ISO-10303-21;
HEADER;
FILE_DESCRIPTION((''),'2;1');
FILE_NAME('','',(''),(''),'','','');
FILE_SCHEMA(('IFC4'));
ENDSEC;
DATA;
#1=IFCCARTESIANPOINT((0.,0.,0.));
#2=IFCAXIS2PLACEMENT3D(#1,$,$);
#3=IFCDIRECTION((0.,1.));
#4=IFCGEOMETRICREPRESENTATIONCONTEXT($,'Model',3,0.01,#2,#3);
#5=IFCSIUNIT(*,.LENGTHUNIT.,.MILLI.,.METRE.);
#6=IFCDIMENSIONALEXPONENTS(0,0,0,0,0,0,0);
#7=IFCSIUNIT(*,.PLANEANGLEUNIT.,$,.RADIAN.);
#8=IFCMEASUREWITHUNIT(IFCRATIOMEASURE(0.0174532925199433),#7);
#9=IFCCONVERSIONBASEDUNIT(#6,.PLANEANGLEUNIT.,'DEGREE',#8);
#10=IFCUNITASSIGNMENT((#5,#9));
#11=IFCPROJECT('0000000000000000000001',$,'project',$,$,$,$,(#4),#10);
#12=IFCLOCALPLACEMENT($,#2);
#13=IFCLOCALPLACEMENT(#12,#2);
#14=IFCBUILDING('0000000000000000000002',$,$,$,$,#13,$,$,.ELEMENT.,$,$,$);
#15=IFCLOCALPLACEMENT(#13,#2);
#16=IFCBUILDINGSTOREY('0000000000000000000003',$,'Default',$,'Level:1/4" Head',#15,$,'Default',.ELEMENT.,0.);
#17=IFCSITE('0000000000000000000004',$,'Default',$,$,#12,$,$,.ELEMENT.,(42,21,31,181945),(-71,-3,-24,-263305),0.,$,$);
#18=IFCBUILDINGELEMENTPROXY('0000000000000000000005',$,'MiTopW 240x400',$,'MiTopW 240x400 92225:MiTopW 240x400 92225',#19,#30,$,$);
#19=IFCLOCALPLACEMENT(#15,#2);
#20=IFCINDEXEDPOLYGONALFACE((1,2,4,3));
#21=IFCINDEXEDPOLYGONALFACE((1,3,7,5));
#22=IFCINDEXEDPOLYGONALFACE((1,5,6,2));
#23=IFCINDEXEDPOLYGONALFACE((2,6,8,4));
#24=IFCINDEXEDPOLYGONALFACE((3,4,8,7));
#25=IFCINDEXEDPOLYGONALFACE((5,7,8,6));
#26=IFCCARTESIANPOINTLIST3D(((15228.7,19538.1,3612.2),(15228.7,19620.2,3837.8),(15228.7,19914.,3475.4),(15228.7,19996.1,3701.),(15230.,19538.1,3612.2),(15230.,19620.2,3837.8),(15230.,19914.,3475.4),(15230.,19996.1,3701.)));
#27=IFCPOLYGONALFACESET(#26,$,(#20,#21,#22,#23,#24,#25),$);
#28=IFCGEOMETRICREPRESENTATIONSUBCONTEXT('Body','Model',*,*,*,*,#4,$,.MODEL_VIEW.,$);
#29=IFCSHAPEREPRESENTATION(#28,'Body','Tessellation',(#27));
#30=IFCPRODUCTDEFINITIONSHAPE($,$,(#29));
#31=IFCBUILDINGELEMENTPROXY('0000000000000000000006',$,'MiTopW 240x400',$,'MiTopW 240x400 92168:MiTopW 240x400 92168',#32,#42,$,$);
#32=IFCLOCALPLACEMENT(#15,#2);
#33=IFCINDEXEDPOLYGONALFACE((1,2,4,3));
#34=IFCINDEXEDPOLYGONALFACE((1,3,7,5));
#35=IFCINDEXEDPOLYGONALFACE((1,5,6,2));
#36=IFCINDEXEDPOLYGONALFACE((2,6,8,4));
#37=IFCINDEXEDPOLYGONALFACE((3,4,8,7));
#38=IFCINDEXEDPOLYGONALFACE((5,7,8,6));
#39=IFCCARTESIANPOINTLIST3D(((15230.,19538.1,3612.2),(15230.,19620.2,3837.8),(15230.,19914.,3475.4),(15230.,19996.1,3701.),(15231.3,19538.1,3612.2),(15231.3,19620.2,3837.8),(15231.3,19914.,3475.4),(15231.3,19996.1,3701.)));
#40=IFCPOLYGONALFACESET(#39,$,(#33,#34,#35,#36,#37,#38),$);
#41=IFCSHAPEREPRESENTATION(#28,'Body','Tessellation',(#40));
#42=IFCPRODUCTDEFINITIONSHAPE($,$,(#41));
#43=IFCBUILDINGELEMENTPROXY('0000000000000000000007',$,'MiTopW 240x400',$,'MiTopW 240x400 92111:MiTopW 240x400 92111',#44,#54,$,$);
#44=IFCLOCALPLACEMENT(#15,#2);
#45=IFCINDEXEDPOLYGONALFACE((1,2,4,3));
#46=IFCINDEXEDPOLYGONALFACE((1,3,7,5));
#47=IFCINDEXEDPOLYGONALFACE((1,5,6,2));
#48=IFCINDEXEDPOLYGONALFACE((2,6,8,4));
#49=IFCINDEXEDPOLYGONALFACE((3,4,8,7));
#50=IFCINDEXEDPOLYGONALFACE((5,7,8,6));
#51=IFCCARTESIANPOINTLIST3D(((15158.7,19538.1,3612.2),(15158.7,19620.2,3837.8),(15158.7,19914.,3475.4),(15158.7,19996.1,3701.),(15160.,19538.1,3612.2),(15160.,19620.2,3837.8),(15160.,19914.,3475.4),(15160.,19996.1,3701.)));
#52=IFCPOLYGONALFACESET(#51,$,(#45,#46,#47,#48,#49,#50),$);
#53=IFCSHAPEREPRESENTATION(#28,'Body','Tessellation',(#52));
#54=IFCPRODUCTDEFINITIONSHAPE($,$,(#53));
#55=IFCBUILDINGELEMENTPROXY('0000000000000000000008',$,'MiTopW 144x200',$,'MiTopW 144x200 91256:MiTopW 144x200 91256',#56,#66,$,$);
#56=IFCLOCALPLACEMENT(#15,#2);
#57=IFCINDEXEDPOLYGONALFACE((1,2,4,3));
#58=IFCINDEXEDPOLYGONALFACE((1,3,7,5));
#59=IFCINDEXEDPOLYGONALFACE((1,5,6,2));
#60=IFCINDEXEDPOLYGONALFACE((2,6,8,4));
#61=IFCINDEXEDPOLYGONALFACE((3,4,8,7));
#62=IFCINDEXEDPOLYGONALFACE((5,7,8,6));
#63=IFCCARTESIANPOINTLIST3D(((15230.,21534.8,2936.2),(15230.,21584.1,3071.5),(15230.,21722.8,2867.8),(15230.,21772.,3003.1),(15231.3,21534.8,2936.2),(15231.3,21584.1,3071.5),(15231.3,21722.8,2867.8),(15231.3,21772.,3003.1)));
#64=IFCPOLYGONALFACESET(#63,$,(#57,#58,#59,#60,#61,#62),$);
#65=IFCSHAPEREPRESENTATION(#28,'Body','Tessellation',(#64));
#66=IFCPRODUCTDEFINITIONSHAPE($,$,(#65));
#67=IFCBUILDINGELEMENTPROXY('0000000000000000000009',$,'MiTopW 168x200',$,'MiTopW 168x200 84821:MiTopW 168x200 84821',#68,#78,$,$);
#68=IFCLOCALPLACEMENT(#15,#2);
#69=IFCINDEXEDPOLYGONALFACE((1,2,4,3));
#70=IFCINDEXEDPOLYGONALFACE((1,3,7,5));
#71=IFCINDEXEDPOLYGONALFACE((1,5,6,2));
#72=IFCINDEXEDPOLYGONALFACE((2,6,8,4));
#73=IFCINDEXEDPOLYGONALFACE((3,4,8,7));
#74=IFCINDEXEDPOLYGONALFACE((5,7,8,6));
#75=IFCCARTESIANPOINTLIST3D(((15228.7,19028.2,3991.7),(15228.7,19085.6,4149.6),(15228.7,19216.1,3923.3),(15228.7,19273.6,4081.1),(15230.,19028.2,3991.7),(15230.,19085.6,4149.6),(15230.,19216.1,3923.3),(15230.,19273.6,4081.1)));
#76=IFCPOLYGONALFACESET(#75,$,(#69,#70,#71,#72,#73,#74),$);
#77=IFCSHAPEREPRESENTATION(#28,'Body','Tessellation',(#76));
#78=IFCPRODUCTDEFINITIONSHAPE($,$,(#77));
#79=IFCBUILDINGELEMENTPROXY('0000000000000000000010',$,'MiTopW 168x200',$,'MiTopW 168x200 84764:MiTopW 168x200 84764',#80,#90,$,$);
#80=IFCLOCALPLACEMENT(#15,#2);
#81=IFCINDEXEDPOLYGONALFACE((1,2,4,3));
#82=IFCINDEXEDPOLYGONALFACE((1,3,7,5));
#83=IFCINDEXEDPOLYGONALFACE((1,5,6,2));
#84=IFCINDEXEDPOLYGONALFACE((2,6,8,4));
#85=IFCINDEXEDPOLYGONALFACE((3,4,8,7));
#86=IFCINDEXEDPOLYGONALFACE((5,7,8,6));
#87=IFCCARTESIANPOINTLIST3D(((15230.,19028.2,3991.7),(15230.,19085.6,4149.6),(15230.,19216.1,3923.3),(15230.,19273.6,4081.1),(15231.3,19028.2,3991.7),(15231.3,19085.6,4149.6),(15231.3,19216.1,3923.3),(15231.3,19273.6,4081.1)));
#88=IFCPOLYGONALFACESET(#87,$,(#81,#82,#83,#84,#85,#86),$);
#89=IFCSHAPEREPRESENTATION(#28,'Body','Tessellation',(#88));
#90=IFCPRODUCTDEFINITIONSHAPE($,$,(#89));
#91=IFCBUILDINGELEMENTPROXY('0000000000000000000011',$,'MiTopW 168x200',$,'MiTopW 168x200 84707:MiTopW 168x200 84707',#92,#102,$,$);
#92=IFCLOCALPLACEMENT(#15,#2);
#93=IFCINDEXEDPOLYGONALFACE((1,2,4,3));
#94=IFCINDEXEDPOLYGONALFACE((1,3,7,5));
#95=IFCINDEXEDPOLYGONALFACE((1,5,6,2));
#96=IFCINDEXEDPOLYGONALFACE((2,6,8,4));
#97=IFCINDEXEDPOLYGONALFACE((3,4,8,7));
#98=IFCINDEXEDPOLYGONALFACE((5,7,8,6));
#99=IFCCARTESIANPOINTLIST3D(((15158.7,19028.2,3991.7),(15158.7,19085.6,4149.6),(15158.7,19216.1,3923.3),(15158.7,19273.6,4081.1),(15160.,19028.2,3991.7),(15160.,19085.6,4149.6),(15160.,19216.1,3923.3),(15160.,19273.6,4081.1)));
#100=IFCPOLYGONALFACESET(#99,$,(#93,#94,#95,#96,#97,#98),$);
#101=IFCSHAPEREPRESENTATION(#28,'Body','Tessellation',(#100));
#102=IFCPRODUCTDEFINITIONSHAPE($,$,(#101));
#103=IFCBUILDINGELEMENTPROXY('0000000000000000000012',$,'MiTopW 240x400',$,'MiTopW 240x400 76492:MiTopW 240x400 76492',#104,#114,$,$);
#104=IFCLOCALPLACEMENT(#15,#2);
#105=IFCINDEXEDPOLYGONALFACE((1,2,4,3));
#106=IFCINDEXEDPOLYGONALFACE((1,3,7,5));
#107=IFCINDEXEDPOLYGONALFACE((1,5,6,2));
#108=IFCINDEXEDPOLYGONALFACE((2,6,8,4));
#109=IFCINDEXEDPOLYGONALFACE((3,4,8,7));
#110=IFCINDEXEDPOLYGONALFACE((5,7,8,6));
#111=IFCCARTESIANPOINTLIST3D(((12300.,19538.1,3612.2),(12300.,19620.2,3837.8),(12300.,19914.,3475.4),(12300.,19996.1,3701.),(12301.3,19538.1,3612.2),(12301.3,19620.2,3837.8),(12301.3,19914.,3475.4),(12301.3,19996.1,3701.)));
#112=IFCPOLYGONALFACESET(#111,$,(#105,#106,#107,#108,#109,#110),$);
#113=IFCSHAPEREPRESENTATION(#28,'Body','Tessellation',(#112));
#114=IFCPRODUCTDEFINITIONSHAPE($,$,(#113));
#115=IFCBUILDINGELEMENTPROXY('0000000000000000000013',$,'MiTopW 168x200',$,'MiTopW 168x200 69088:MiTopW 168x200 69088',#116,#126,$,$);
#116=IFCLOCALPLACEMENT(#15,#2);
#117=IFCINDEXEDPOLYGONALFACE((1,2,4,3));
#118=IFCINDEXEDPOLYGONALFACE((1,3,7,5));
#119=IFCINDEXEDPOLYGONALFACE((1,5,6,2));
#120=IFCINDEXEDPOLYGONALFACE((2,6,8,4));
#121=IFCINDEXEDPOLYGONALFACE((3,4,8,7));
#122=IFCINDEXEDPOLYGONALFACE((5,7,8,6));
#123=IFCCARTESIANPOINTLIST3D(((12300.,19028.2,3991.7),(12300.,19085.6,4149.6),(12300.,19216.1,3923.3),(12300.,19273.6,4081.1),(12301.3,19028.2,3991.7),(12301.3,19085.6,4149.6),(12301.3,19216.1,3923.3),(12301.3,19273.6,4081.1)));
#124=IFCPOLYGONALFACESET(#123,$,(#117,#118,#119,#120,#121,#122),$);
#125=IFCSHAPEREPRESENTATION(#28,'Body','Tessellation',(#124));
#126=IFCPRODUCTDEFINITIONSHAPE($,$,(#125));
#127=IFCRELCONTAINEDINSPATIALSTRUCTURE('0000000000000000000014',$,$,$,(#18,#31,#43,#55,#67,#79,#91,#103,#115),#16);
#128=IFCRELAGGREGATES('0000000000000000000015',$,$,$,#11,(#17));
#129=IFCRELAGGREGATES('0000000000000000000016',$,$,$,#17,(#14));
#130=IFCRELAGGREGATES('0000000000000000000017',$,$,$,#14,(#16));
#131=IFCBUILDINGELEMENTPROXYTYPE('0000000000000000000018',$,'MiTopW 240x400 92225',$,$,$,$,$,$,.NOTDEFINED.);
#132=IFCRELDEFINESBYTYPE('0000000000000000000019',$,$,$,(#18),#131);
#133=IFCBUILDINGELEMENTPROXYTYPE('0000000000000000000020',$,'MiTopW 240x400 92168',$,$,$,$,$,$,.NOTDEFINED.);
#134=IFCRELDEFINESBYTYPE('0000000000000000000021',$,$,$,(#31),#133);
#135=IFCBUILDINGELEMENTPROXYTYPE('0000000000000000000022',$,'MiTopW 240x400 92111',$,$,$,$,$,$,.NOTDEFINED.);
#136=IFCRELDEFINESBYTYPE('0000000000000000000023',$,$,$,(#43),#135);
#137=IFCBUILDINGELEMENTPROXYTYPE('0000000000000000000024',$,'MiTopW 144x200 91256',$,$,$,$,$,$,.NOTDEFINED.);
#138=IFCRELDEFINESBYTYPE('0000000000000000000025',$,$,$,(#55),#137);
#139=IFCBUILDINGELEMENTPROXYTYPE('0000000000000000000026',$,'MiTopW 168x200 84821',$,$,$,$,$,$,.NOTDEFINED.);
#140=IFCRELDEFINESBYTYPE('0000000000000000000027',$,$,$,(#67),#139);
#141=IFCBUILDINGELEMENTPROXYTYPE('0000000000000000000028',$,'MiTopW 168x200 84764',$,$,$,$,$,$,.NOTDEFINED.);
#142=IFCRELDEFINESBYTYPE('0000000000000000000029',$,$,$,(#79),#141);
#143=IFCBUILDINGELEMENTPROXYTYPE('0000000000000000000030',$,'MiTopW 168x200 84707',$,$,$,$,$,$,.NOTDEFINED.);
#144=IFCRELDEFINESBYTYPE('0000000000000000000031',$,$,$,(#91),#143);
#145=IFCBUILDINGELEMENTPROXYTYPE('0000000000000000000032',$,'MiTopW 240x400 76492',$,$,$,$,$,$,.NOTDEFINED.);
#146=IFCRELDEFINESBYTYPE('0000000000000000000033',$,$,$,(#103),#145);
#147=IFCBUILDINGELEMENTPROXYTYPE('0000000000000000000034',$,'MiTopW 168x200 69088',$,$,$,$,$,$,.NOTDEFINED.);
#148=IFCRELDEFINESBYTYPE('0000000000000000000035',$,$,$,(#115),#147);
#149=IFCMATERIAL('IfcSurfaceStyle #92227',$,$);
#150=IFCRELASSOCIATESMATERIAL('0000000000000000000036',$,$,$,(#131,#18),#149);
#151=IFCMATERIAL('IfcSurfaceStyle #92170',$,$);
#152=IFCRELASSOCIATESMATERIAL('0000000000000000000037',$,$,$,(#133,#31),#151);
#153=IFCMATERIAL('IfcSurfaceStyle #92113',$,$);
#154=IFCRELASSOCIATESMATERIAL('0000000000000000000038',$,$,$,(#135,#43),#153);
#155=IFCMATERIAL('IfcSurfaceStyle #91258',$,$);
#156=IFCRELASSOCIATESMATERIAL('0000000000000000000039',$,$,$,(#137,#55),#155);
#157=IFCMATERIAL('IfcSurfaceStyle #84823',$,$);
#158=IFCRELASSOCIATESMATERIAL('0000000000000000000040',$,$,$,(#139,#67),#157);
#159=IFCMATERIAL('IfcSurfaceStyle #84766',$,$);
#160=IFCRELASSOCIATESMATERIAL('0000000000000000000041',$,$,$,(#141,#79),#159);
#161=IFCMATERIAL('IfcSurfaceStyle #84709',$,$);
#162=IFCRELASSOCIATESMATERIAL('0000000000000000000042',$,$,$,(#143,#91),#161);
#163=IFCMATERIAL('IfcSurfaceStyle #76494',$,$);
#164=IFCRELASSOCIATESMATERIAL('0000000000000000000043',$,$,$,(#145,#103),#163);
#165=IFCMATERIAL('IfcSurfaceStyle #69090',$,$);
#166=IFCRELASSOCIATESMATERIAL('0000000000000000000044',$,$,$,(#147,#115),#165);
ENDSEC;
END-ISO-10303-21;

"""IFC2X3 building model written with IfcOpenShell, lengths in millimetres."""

from ifc_helpers import new_model, entity, si_unit, converted_unit, direction, frame, origin, place, context, subcontext, project, spatial, polyline, outline, extrude, source, transform, mapped, material, type_object, type_shapes, element, save


model = new_model("IFC2X3")

# Units and contexts
model_context = context("Model", 3, precision=0.01, world=origin(), true_north=direction((0.0, 1.0)))
body_context = subcontext(model_context, "Body", "Model", "MODEL_VIEW")
ifc_project = project(units=[si_unit("LENGTHUNIT", "METRE", prefix="MILLI"), converted_unit("PLANEANGLEUNIT", "DEGREE", entity("IfcRatioMeasure", 0.0174532925199433), si_unit("PLANEANGLEUNIT", "RADIAN"), dimensions=[0, 0, 0, 0, 0, 0, 0])], contexts=[model_context])

# Site, building, storey
site_placement = place(None, origin())
site = spatial("IfcSite", under=ifc_project, at=site_placement, Name="Default", CompositionType="ELEMENT", RefLatitude=(42, 21, 31, 181945), RefLongitude=(-71, -3, -24, -263305), RefElevation=0.0)
building_placement = place(site_placement, origin())
building = spatial("IfcBuilding", under=site, at=building_placement, CompositionType="ELEMENT")
storey_placement = place(building_placement, origin())
storey = spatial("IfcBuildingStorey", under=building, at=storey_placement, Name="Default", ObjectType="Level:1/4\" Head", LongName="Default", CompositionType="ELEMENT", Elevation=0.0)

# Building element proxies
ifc_material_1 = material(Name="IfcSurfaceStyle #92227")
building_element_proxy_type_1 = type_object("IfcBuildingElementProxyType", Name="MiTopW 240x400 92225", PredefinedType="NOTDEFINED", material=ifc_material_1)
shared_shape_1 = source(origin(), body_context, "Body", "SweptSolid", [
    extrude(outline(polyline([(-200.0, -120.0), (200.0, -120.0), (200.0, 120.0), (-200.0, 120.0), (-200.0, -120.0)])), frame((200.0, 120.0, 0.0), z_axis=(0.0, 0.0, 1.0), x_axis=(-1.0, 0.0, 0.0)), (0.0, 0.0, 1.0), 1.3),
])
type_shapes(building_element_proxy_type_1, [shared_shape_1])
proxy_1_placement = place(building_placement, frame((15230.0, 19620.2, 3837.8), z_axis=(-1.0, 0.0, 0.0), x_axis=(0.0, 0.939693, -0.34202)))
element("IfcBuildingElementProxy", 1, at=proxy_1_placement, inside=storey, type_object=building_element_proxy_type_1, material=ifc_material_1, Name="MiTopW 240x400", ObjectType="MiTopW 240x400 92225:MiTopW 240x400 92225", context=body_context, shape_type="MappedRepresentation", body=[
    mapped(shared_shape_1, transform((0.0, 0.0, 0.0), scale=1.0)),
])
ifc_material_2 = material(Name="IfcSurfaceStyle #92170")
building_element_proxy_type_2 = type_object("IfcBuildingElementProxyType", Name="MiTopW 240x400 92168", PredefinedType="NOTDEFINED", material=ifc_material_2)
shared_shape_2 = source(origin(), body_context, "Body", "SweptSolid", [
    extrude(outline(polyline([(-200.0, -120.0), (200.0, -120.0), (200.0, 120.0), (-200.0, 120.0), (-200.0, -120.0)])), frame((200.0, 120.0, 0.0), z_axis=(0.0, 0.0, 1.0), x_axis=(-1.0, 0.0, 0.0)), (0.0, 0.0, 1.0), 1.3),
])
type_shapes(building_element_proxy_type_2, [shared_shape_2])
proxy_2_placement = place(building_placement, frame((15231.3, 19620.2, 3837.8), z_axis=(-1.0, 0.0, 0.0), x_axis=(0.0, 0.939693, -0.34202)))
element("IfcBuildingElementProxy", 2, at=proxy_2_placement, inside=storey, type_object=building_element_proxy_type_2, material=ifc_material_2, Name="MiTopW 240x400", ObjectType="MiTopW 240x400 92168:MiTopW 240x400 92168", context=body_context, shape_type="MappedRepresentation", body=[
    mapped(shared_shape_2, transform((0.0, 0.0, 0.0), scale=1.0)),
])
ifc_material_3 = material(Name="IfcSurfaceStyle #92113")
building_element_proxy_type_3 = type_object("IfcBuildingElementProxyType", Name="MiTopW 240x400 92111", PredefinedType="NOTDEFINED", material=ifc_material_3)
shared_shape_3 = source(origin(), body_context, "Body", "SweptSolid", [
    extrude(outline(polyline([(-200.0, -120.0), (200.0, -120.0), (200.0, 120.0), (-200.0, 120.0), (-200.0, -120.0)])), frame((200.0, 120.0, 0.0), z_axis=(0.0, 0.0, 1.0), x_axis=(-1.0, 0.0, 0.0)), (0.0, 0.0, 1.0), 1.3),
])
type_shapes(building_element_proxy_type_3, [shared_shape_3])
proxy_3_placement = place(building_placement, frame((15160.0, 19620.2, 3837.8), z_axis=(-1.0, 0.0, 0.0), x_axis=(0.0, 0.939693, -0.34202)))
element("IfcBuildingElementProxy", 3, at=proxy_3_placement, inside=storey, type_object=building_element_proxy_type_3, material=ifc_material_3, Name="MiTopW 240x400", ObjectType="MiTopW 240x400 92111:MiTopW 240x400 92111", context=body_context, shape_type="MappedRepresentation", body=[
    mapped(shared_shape_3, transform((0.0, 0.0, 0.0), scale=1.0)),
])
ifc_material_4 = material(Name="IfcSurfaceStyle #91258")
building_element_proxy_type_4 = type_object("IfcBuildingElementProxyType", Name="MiTopW 144x200 91256", PredefinedType="NOTDEFINED", material=ifc_material_4)
shared_shape_4 = source(origin(), body_context, "Body", "SweptSolid", [
    extrude(outline(polyline([(-100.0, -72.0), (100.0, -72.0), (100.0, 72.0), (-100.0, 72.0), (-100.0, -72.0)])), frame((100.0, 72.0, 0.0), z_axis=(0.0, 0.0, 1.0), x_axis=(-1.0, 0.0, 0.0)), (0.0, 0.0, 1.0), 1.3),
])
type_shapes(building_element_proxy_type_4, [shared_shape_4])
proxy_4_placement = place(building_placement, frame((15231.3, 21584.1, 3071.5), z_axis=(-1.0, 0.0, 0.0), x_axis=(0.0, 0.939693, -0.34202)))
element("IfcBuildingElementProxy", 4, at=proxy_4_placement, inside=storey, type_object=building_element_proxy_type_4, material=ifc_material_4, Name="MiTopW 144x200", ObjectType="MiTopW 144x200 91256:MiTopW 144x200 91256", context=body_context, shape_type="MappedRepresentation", body=[
    mapped(shared_shape_4, transform((0.0, 0.0, 0.0), scale=1.0)),
])
ifc_material_5 = material(Name="IfcSurfaceStyle #84823")
building_element_proxy_type_5 = type_object("IfcBuildingElementProxyType", Name="MiTopW 168x200 84821", PredefinedType="NOTDEFINED", material=ifc_material_5)
shared_shape_5 = source(origin(), body_context, "Body", "SweptSolid", [
    extrude(outline(polyline([(-100.0, -84.0), (100.0, -84.0), (100.0, 84.0), (-100.0, 84.0), (-100.0, -84.0)])), frame((100.0, 84.0, 0.0), z_axis=(0.0, 0.0, 1.0), x_axis=(-1.0, 0.0, 0.0)), (0.0, 0.0, 1.0), 1.3),
])
type_shapes(building_element_proxy_type_5, [shared_shape_5])
proxy_5_placement = place(building_placement, frame((15230.0, 19216.1, 3923.3), z_axis=(-1.0, 0.0, 0.0), x_axis=(0.0, -0.939693, 0.34202)))
element("IfcBuildingElementProxy", 5, at=proxy_5_placement, inside=storey, type_object=building_element_proxy_type_5, material=ifc_material_5, Name="MiTopW 168x200", ObjectType="MiTopW 168x200 84821:MiTopW 168x200 84821", context=body_context, shape_type="MappedRepresentation", body=[
    mapped(shared_shape_5, transform((0.0, 0.0, 0.0), scale=1.0)),
])
ifc_material_6 = material(Name="IfcSurfaceStyle #84766")
building_element_proxy_type_6 = type_object("IfcBuildingElementProxyType", Name="MiTopW 168x200 84764", PredefinedType="NOTDEFINED", material=ifc_material_6)
shared_shape_6 = source(origin(), body_context, "Body", "SweptSolid", [
    extrude(outline(polyline([(-100.0, -84.0), (100.0, -84.0), (100.0, 84.0), (-100.0, 84.0), (-100.0, -84.0)])), frame((100.0, 84.0, 0.0), z_axis=(0.0, 0.0, 1.0), x_axis=(-1.0, 0.0, 0.0)), (0.0, 0.0, 1.0), 1.3),
])
type_shapes(building_element_proxy_type_6, [shared_shape_6])
proxy_6_placement = place(building_placement, frame((15231.3, 19216.1, 3923.3), z_axis=(-1.0, 0.0, 0.0), x_axis=(0.0, -0.939693, 0.34202)))
element("IfcBuildingElementProxy", 6, at=proxy_6_placement, inside=storey, type_object=building_element_proxy_type_6, material=ifc_material_6, Name="MiTopW 168x200", ObjectType="MiTopW 168x200 84764:MiTopW 168x200 84764", context=body_context, shape_type="MappedRepresentation", body=[
    mapped(shared_shape_6, transform((0.0, 0.0, 0.0), scale=1.0)),
])
ifc_material_7 = material(Name="IfcSurfaceStyle #84709")
building_element_proxy_type_7 = type_object("IfcBuildingElementProxyType", Name="MiTopW 168x200 84707", PredefinedType="NOTDEFINED", material=ifc_material_7)
shared_shape_7 = source(origin(), body_context, "Body", "SweptSolid", [
    extrude(outline(polyline([(-100.0, -84.0), (100.0, -84.0), (100.0, 84.0), (-100.0, 84.0), (-100.0, -84.0)])), frame((100.0, 84.0, 0.0), z_axis=(0.0, 0.0, 1.0), x_axis=(-1.0, 0.0, 0.0)), (0.0, 0.0, 1.0), 1.3),
])
type_shapes(building_element_proxy_type_7, [shared_shape_7])
proxy_7_placement = place(building_placement, frame((15160.0, 19216.1, 3923.3), z_axis=(-1.0, 0.0, 0.0), x_axis=(0.0, -0.939693, 0.34202)))
element("IfcBuildingElementProxy", 7, at=proxy_7_placement, inside=storey, type_object=building_element_proxy_type_7, material=ifc_material_7, Name="MiTopW 168x200", ObjectType="MiTopW 168x200 84707:MiTopW 168x200 84707", context=body_context, shape_type="MappedRepresentation", body=[
    mapped(shared_shape_7, transform((0.0, 0.0, 0.0), scale=1.0)),
])
ifc_material_8 = material(Name="IfcSurfaceStyle #76494")
building_element_proxy_type_8 = type_object("IfcBuildingElementProxyType", Name="MiTopW 240x400 76492", PredefinedType="NOTDEFINED", material=ifc_material_8)
shared_shape_8 = source(origin(), body_context, "Body", "SweptSolid", [
    extrude(outline(polyline([(-200.0, -120.0), (200.0, -120.0), (200.0, 120.0), (-200.0, 120.0), (-200.0, -120.0)])), frame((200.0, 120.0, 0.0), z_axis=(0.0, 0.0, 1.0), x_axis=(-1.0, 0.0, 0.0)), (0.0, 0.0, 1.0), 1.3),
])
type_shapes(building_element_proxy_type_8, [shared_shape_8])
proxy_8_placement = place(building_placement, frame((12301.3, 19620.2, 3837.8), z_axis=(-1.0, 0.0, 0.0), x_axis=(0.0, 0.939693, -0.34202)))
element("IfcBuildingElementProxy", 8, at=proxy_8_placement, inside=storey, type_object=building_element_proxy_type_8, material=ifc_material_8, Name="MiTopW 240x400", ObjectType="MiTopW 240x400 76492:MiTopW 240x400 76492", context=body_context, shape_type="MappedRepresentation", body=[
    mapped(shared_shape_8, transform((0.0, 0.0, 0.0), scale=1.0)),
])
ifc_material_9 = material(Name="IfcSurfaceStyle #69090")
building_element_proxy_type_9 = type_object("IfcBuildingElementProxyType", Name="MiTopW 168x200 69088", PredefinedType="NOTDEFINED", material=ifc_material_9)
shared_shape_9 = source(origin(), body_context, "Body", "SweptSolid", [
    extrude(outline(polyline([(-100.0, -84.0), (100.0, -84.0), (100.0, 84.0), (-100.0, 84.0), (-100.0, -84.0)])), frame((100.0, 84.0, 0.0), z_axis=(0.0, 0.0, 1.0), x_axis=(-1.0, 0.0, 0.0)), (0.0, 0.0, 1.0), 1.3),
])
type_shapes(building_element_proxy_type_9, [shared_shape_9])
proxy_9_placement = place(building_placement, frame((12301.3, 19216.1, 3923.3), z_axis=(-1.0, 0.0, 0.0), x_axis=(0.0, -0.939693, 0.34202)))
element("IfcBuildingElementProxy", 9, at=proxy_9_placement, inside=storey, type_object=building_element_proxy_type_9, material=ifc_material_9, Name="MiTopW 168x200", ObjectType="MiTopW 168x200 69088:MiTopW 168x200 69088", context=body_context, shape_type="MappedRepresentation", body=[
    mapped(shared_shape_9, transform((0.0, 0.0, 0.0), scale=1.0)),
])

save(model, "model.ifc")
